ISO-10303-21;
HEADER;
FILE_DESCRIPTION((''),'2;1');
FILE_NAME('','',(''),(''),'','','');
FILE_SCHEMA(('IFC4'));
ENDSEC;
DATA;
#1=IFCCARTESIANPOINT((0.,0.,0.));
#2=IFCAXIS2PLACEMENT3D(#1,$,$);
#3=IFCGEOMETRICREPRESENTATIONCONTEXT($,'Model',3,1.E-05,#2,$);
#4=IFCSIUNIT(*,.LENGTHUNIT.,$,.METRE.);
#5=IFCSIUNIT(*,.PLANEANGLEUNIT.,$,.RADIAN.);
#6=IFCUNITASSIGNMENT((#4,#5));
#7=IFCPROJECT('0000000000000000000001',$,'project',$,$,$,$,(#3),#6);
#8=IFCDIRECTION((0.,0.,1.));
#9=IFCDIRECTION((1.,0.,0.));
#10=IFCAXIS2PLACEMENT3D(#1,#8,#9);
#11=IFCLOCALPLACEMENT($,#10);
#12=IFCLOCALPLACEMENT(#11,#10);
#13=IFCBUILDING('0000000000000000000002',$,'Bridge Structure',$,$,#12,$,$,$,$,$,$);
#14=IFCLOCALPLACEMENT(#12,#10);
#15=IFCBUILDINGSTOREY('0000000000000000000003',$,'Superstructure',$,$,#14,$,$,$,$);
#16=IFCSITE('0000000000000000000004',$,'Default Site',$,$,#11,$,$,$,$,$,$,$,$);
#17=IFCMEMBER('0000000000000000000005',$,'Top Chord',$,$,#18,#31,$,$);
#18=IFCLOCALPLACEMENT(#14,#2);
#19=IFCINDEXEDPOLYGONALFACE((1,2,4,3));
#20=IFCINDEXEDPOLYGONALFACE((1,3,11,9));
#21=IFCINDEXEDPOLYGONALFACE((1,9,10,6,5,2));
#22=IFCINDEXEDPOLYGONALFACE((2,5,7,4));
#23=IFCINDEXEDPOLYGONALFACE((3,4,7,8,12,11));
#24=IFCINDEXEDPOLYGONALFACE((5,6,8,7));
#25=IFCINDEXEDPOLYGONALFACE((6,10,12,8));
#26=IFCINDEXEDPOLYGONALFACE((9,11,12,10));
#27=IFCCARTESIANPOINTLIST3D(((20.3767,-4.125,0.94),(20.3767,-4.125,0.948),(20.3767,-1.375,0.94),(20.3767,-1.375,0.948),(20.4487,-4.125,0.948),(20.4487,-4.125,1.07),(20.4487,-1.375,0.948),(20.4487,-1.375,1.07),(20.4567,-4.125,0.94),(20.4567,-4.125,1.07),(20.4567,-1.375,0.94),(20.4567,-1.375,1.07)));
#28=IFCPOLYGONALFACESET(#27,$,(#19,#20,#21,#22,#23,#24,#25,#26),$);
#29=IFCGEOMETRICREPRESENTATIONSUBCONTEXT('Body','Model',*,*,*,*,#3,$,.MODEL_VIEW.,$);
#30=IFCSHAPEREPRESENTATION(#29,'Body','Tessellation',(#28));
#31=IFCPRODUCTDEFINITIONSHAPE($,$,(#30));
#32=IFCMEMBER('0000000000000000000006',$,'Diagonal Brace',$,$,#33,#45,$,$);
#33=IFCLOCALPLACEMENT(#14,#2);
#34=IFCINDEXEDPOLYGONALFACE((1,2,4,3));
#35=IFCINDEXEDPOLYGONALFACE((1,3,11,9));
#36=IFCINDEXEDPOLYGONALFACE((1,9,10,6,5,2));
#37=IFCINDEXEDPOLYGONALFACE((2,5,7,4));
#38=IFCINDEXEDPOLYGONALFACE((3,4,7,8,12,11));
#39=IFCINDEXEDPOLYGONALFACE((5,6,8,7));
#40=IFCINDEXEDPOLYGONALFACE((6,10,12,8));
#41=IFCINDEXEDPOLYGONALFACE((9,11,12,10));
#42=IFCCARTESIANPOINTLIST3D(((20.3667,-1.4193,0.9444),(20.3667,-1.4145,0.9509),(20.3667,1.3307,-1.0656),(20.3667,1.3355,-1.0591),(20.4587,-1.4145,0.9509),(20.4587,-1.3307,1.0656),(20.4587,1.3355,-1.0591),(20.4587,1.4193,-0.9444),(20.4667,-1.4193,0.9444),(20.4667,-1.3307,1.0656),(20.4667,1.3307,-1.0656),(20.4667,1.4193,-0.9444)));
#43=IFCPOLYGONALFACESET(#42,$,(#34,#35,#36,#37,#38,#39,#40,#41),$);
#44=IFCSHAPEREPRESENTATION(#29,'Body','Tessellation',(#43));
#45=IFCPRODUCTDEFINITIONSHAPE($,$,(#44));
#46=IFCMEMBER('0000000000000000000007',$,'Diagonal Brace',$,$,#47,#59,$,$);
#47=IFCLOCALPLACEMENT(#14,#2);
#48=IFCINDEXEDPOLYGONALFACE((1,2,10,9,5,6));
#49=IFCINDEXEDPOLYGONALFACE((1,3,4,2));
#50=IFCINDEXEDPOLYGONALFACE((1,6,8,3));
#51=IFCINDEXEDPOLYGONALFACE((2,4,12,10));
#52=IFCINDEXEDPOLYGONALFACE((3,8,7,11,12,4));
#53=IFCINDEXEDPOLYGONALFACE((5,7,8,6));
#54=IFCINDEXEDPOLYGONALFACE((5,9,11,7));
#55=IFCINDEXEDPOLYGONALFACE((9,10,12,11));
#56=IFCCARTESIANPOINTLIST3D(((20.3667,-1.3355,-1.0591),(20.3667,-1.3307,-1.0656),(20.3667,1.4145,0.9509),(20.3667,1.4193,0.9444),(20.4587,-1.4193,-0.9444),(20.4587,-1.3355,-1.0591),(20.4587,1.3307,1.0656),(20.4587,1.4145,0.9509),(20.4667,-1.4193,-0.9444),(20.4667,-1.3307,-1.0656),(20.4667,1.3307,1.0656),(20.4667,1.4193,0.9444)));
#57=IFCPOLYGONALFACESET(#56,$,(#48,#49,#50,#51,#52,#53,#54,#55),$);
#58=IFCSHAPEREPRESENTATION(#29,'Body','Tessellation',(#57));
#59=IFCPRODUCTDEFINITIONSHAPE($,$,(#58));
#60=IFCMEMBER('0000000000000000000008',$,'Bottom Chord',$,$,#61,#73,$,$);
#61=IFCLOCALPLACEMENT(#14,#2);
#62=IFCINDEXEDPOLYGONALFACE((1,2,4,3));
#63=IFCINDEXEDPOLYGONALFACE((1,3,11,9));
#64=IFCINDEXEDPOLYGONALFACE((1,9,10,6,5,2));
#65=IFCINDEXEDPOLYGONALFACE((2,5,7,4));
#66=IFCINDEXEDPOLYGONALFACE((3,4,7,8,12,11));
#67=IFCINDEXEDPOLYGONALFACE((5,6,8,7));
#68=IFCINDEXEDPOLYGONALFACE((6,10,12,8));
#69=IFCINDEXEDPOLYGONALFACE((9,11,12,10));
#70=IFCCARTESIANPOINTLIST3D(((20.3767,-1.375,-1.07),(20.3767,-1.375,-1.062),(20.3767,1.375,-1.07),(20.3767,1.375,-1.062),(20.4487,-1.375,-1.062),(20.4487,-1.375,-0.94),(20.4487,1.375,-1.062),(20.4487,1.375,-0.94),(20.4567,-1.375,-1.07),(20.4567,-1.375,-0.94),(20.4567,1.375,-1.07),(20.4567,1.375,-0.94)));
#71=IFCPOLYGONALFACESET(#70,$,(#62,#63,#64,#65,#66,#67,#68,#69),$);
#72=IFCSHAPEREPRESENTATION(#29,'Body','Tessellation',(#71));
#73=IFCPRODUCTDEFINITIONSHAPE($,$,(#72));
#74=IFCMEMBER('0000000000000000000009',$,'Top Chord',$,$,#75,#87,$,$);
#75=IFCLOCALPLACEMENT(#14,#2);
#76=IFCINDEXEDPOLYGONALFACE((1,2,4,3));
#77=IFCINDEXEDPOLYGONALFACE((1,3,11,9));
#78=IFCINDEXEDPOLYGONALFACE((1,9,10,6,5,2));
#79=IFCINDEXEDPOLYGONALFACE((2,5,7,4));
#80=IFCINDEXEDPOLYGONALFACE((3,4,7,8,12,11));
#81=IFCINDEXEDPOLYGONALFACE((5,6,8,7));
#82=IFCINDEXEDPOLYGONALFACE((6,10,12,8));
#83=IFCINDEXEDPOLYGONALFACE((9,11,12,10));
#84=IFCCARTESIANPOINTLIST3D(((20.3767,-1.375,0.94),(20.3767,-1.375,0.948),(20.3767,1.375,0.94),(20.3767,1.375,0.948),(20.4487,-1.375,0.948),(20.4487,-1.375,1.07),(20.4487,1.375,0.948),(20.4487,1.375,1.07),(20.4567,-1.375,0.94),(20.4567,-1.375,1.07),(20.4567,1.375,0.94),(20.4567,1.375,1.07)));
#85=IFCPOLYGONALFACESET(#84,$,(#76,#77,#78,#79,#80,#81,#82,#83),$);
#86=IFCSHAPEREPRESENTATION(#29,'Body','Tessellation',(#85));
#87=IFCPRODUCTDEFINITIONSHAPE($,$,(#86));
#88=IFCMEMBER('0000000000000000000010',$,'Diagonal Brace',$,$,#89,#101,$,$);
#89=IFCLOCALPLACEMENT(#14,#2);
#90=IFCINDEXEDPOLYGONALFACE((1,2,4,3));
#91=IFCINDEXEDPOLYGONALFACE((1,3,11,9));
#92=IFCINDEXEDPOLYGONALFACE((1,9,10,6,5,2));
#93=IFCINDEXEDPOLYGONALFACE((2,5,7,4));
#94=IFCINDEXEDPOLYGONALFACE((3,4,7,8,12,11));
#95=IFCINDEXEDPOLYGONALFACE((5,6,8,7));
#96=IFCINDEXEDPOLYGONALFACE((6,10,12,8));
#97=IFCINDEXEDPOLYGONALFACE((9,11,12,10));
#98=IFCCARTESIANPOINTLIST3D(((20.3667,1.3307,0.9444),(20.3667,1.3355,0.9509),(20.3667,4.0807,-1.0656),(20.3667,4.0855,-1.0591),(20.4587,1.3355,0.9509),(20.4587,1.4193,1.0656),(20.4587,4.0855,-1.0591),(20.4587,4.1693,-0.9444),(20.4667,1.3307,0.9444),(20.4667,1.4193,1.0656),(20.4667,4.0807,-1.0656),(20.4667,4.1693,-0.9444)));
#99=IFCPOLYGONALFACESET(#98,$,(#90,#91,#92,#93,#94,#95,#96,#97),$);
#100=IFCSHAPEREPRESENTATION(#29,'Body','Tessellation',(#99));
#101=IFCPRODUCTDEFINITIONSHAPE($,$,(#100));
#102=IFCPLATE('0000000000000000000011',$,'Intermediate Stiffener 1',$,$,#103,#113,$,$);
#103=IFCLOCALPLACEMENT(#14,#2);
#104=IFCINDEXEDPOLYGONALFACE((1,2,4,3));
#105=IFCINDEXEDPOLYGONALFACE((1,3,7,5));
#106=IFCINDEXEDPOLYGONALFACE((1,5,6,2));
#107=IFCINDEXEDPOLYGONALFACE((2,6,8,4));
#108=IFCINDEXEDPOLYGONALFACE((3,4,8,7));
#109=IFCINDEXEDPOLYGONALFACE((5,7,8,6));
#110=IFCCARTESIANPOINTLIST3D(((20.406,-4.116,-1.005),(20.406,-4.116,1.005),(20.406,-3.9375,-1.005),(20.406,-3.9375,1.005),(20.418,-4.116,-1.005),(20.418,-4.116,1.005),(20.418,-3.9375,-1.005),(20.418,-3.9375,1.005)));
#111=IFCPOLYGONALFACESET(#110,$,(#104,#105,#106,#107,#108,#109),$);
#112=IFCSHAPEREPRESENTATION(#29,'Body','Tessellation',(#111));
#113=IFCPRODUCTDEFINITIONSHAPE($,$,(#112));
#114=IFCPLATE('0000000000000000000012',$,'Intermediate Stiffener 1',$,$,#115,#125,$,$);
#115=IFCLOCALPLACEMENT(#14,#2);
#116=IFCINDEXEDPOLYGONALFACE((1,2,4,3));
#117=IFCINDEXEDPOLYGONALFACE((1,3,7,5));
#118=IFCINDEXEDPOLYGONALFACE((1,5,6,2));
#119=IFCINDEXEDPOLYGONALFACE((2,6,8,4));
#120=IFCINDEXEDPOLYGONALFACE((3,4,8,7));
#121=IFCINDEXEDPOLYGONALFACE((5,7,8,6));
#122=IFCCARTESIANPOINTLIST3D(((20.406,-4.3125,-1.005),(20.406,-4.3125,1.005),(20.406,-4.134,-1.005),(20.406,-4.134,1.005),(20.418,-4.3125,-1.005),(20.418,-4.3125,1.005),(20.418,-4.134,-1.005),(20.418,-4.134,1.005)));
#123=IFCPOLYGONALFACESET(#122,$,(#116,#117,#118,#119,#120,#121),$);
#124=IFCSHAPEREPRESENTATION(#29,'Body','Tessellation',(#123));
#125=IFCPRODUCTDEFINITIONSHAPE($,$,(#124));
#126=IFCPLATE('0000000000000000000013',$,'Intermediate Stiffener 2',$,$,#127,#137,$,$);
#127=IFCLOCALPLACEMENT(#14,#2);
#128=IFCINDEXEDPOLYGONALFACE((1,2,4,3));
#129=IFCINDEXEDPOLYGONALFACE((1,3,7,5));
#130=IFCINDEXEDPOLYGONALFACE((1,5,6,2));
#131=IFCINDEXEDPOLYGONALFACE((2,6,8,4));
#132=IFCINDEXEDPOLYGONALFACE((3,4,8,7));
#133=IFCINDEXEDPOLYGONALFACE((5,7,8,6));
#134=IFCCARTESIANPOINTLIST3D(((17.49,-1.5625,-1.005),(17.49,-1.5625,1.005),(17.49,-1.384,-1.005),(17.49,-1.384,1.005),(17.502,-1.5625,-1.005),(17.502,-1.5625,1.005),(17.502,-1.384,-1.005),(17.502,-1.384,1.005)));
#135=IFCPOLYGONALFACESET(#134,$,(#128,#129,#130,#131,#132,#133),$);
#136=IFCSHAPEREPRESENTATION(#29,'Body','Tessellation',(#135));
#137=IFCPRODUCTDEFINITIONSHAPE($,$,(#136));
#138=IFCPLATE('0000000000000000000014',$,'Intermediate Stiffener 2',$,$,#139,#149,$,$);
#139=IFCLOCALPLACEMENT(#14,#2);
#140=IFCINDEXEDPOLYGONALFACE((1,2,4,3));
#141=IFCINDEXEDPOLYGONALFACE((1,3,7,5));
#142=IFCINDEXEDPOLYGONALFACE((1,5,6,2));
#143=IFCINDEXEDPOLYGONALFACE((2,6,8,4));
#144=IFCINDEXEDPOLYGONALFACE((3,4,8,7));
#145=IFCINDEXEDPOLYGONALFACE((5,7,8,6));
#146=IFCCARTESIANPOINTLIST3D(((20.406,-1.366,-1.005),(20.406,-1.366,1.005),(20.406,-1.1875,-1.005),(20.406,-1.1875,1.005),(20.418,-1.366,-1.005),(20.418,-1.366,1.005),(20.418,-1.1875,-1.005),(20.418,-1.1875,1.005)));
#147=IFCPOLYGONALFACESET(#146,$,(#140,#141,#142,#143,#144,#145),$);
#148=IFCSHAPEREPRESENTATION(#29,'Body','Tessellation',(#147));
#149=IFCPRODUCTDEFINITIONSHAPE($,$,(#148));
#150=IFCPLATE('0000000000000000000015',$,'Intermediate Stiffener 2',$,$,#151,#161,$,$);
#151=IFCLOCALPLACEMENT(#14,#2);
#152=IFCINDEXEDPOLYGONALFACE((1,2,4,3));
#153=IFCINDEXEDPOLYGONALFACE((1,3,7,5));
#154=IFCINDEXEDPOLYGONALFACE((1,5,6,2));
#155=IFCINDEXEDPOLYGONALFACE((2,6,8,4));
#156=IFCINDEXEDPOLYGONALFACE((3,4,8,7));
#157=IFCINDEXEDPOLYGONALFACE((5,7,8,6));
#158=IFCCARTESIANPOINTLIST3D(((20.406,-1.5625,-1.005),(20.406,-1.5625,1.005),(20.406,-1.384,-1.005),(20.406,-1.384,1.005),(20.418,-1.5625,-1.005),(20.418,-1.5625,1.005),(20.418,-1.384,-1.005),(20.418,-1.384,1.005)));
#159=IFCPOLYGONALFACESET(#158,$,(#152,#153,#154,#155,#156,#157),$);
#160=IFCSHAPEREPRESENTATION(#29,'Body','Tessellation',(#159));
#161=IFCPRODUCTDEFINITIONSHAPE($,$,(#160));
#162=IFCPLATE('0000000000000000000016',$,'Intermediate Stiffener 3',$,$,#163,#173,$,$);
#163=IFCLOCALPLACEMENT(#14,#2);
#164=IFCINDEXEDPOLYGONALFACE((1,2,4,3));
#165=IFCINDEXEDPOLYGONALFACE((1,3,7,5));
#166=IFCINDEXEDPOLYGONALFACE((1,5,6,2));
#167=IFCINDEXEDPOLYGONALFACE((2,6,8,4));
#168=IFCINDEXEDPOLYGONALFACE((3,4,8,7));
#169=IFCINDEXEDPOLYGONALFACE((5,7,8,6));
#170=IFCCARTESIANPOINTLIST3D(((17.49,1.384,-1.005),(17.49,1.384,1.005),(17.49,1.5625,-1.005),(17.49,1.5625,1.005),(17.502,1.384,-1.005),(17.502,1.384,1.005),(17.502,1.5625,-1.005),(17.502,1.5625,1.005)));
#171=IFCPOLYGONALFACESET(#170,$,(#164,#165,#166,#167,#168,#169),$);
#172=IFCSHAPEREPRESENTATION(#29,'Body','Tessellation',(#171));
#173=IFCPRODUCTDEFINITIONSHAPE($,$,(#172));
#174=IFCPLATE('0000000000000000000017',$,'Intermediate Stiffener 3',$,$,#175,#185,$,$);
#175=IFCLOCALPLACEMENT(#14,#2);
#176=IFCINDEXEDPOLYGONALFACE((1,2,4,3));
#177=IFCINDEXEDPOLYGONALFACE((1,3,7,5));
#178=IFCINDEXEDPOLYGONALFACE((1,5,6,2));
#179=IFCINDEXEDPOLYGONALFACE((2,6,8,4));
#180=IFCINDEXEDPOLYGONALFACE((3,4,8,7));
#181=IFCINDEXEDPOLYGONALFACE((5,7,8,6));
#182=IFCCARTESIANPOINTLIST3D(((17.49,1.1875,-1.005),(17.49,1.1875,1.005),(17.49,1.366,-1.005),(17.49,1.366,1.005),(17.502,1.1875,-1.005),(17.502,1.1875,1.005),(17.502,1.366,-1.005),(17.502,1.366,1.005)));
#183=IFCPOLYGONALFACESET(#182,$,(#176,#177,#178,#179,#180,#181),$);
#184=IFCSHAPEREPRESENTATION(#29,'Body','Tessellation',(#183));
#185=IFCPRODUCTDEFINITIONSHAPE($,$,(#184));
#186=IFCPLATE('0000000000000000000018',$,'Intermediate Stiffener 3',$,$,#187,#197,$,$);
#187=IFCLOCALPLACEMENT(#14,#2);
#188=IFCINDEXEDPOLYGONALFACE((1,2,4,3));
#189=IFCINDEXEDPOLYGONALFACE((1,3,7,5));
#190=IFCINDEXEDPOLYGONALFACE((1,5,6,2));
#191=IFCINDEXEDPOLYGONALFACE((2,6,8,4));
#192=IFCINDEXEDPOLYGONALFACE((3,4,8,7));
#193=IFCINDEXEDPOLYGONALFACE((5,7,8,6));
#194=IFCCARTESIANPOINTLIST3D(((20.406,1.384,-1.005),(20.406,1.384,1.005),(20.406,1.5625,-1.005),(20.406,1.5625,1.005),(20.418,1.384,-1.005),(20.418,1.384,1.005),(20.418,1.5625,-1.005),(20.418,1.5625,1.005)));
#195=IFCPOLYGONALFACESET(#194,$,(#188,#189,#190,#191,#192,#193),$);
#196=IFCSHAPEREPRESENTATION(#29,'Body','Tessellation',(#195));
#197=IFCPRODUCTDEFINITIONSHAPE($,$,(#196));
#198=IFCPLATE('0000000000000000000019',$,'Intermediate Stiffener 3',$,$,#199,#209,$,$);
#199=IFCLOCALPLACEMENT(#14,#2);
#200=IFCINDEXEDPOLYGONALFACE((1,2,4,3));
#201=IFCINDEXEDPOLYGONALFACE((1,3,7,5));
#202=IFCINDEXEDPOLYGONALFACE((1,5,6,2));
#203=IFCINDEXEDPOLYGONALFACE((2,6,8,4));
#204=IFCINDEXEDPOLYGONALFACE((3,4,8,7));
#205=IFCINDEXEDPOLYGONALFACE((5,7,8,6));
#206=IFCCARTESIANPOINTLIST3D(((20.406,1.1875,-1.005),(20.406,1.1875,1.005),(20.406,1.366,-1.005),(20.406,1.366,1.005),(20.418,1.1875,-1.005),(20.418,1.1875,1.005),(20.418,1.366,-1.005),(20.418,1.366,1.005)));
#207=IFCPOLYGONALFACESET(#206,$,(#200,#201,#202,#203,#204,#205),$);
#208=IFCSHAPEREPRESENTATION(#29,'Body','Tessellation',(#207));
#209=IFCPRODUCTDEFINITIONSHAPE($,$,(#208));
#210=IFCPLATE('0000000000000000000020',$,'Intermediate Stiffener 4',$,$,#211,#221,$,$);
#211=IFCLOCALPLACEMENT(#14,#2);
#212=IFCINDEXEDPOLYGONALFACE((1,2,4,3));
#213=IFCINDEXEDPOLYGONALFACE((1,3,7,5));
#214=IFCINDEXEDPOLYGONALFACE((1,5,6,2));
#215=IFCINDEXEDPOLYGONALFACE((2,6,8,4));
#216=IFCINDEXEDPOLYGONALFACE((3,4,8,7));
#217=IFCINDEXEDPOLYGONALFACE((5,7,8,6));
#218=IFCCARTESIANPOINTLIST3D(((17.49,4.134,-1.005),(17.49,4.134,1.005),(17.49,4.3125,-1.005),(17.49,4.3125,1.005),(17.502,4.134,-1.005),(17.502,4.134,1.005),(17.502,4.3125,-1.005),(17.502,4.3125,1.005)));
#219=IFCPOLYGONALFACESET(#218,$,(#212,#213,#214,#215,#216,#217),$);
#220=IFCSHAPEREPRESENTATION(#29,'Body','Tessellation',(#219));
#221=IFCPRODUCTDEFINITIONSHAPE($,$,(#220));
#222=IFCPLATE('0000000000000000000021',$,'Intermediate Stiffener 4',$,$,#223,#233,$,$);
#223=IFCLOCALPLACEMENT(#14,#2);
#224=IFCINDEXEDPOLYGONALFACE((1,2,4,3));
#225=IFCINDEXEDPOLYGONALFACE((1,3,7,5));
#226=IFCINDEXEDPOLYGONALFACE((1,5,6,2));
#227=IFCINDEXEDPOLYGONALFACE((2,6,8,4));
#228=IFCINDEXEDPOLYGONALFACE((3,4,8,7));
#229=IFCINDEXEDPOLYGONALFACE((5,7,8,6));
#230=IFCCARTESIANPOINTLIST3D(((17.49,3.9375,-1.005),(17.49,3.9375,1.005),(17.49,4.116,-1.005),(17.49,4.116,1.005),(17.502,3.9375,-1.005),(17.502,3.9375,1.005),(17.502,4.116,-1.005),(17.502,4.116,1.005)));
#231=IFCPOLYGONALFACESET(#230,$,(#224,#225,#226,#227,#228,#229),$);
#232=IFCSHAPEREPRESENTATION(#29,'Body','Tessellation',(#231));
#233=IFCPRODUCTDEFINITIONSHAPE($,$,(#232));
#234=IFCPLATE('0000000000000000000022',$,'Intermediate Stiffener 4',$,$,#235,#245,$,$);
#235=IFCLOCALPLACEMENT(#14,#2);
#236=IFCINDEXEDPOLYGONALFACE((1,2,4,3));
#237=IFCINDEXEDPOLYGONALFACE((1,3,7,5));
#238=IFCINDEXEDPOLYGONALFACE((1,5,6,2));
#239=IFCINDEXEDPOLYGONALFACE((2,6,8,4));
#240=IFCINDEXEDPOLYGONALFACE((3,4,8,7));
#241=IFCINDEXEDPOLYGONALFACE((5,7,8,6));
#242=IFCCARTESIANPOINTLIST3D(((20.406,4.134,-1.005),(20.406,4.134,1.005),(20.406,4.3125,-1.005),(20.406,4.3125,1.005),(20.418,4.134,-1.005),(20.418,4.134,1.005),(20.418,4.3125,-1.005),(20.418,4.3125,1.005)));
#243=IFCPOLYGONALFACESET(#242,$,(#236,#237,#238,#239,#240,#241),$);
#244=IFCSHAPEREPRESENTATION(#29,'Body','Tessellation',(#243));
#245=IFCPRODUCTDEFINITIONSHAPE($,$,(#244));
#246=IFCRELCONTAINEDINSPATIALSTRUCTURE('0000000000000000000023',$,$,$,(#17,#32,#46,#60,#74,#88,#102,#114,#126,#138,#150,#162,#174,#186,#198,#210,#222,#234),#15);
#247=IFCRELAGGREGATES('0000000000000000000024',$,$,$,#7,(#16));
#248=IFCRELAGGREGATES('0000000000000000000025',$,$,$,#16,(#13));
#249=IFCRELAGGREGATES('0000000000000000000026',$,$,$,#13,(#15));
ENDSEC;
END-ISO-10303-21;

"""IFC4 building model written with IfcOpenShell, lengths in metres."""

from ifc_helpers import new_model, si_unit, frame, origin, origin_with_axes, origin_2d_with_axis, place, context, subcontext, project, spatial, rectangle, l_section, extrude, element, save


model = new_model("IFC4")

# Units and contexts
model_context = context("Model", 3, precision=1e-05, world=origin())
body_context = subcontext(model_context, "Body", "Model", "MODEL_VIEW")
ifc_project = project(units=[si_unit("LENGTHUNIT", "METRE"), si_unit("PLANEANGLEUNIT", "RADIAN")], contexts=[model_context])

# Site, building, storey
site_placement = place(None, origin_with_axes())
site = spatial("IfcSite", under=ifc_project, at=site_placement, Name="Default Site")
building_placement = place(site_placement, origin_with_axes())
building = spatial("IfcBuilding", under=site, at=building_placement, Name="Bridge Structure")
storey_placement = place(building_placement, origin_with_axes())
storey = spatial("IfcBuildingStorey", under=building, at=storey_placement, Name="Superstructure")

# Members
for number, where, z_axis, x_axis, name in (
    (1, (20.4167, -4.125, 1.005), (0.0, 1.0, 0.0), (-1.0, 0.0, 0.0), "Top Chord"),
):
    element("IfcMember", number, at=place(storey_placement, frame(where, z_axis=z_axis, x_axis=x_axis)), inside=storey, Name=name, context=body_context, shape_type="SweptSolid", body=[
        extrude(l_section(Depth=0.13, Width=0.08, Thickness=0.008, at=origin_2d_with_axis()), origin_with_axes(), (0.0, 0.0, 1.0), 2.75),
    ])
for number, where, z_axis, x_axis, name in (
    (2, (20.4167, -1.375, 1.005), (0.0, 0.807337, -0.59009), (-1.0, 0.0, 0.0), "Diagonal Brace"),
    (3, (20.4167, -1.375, -1.005), (0.0, 0.807337, 0.59009), (-1.0, 0.0, 0.0), "Diagonal Brace"),
):
    element("IfcMember", number, at=place(storey_placement, frame(where, z_axis=z_axis, x_axis=x_axis)), inside=storey, Name=name, context=body_context, shape_type="SweptSolid", body=[
        extrude(l_section(Depth=0.15, Width=0.1, Thickness=0.008, at=origin_2d_with_axis()), origin_with_axes(), (0.0, 0.0, 1.0), 3.4063),
    ])
for number, where, z_axis, x_axis, name in (
    (4, (20.4167, -1.375, -1.005), (0.0, 1.0, 0.0), (-1.0, 0.0, 0.0), "Bottom Chord"),
    (5, (20.4167, -1.375, 1.005), (0.0, 1.0, 0.0), (-1.0, 0.0, 0.0), "Top Chord"),
):
    element("IfcMember", number, at=place(storey_placement, frame(where, z_axis=z_axis, x_axis=x_axis)), inside=storey, Name=name, context=body_context, shape_type="SweptSolid", body=[
        extrude(l_section(Depth=0.13, Width=0.08, Thickness=0.008, at=origin_2d_with_axis()), origin_with_axes(), (0.0, 0.0, 1.0), 2.75),
    ])
member_placement = place(storey_placement, frame((20.4167, 1.375, 1.005), z_axis=(0.0, 0.807337, -0.59009), x_axis=(-1.0, 0.0, 0.0)))
element("IfcMember", 6, at=member_placement, inside=storey, Name="Diagonal Brace", context=body_context, shape_type="SweptSolid", body=[
    extrude(l_section(Depth=0.15, Width=0.1, Thickness=0.008, at=origin_2d_with_axis()), origin_with_axes(), (0.0, 0.0, 1.0), 3.4063),
])

# Plates
for number, where, z_axis, x_axis, name in (
    (7, (20.412, -4.0267, -1.005), (0.0, 0.0, 1.0), (1.0, 0.0, 0.0), "Intermediate Stiffener 1"),
    (8, (20.412, -4.2233, -1.005), (0.0, 0.0, 1.0), (1.0, 0.0, 0.0), "Intermediate Stiffener 1"),
    (9, (17.496, -1.4732, -1.005), (0.0, 0.0, 1.0), (1.0, 0.0, 0.0), "Intermediate Stiffener 2"),
    (10, (20.412, -1.2768, -1.005), (0.0, 0.0, 1.0), (1.0, 0.0, 0.0), "Intermediate Stiffener 2"),
    (11, (20.412, -1.4732, -1.005), (0.0, 0.0, 1.0), (1.0, 0.0, 0.0), "Intermediate Stiffener 2"),
    (12, (17.496, 1.4732, -1.005), (0.0, 0.0, 1.0), (1.0, 0.0, 0.0), "Intermediate Stiffener 3"),
    (13, (17.496, 1.2768, -1.005), (0.0, 0.0, 1.0), (1.0, 0.0, 0.0), "Intermediate Stiffener 3"),
    (14, (20.412, 1.4732, -1.005), (0.0, 0.0, 1.0), (1.0, 0.0, 0.0), "Intermediate Stiffener 3"),
    (15, (20.412, 1.2768, -1.005), (0.0, 0.0, 1.0), (1.0, 0.0, 0.0), "Intermediate Stiffener 3"),
    (16, (17.496, 4.2233, -1.005), (0.0, 0.0, 1.0), (1.0, 0.0, 0.0), "Intermediate Stiffener 4"),
    (17, (17.496, 4.0267, -1.005), (0.0, 0.0, 1.0), (1.0, 0.0, 0.0), "Intermediate Stiffener 4"),
    (18, (20.412, 4.2233, -1.005), (0.0, 0.0, 1.0), (1.0, 0.0, 0.0), "Intermediate Stiffener 4"),
):
    element("IfcPlate", number, at=place(storey_placement, frame(where, z_axis=z_axis, x_axis=x_axis)), inside=storey, Name=name, context=body_context, shape_type="SweptSolid", body=[
        extrude(rectangle(XDim=0.012, YDim=0.1785, at=origin_2d_with_axis()), origin_with_axes(), (0.0, 0.0, 1.0), 2.01),
    ])

save(model, "model.ifc")
